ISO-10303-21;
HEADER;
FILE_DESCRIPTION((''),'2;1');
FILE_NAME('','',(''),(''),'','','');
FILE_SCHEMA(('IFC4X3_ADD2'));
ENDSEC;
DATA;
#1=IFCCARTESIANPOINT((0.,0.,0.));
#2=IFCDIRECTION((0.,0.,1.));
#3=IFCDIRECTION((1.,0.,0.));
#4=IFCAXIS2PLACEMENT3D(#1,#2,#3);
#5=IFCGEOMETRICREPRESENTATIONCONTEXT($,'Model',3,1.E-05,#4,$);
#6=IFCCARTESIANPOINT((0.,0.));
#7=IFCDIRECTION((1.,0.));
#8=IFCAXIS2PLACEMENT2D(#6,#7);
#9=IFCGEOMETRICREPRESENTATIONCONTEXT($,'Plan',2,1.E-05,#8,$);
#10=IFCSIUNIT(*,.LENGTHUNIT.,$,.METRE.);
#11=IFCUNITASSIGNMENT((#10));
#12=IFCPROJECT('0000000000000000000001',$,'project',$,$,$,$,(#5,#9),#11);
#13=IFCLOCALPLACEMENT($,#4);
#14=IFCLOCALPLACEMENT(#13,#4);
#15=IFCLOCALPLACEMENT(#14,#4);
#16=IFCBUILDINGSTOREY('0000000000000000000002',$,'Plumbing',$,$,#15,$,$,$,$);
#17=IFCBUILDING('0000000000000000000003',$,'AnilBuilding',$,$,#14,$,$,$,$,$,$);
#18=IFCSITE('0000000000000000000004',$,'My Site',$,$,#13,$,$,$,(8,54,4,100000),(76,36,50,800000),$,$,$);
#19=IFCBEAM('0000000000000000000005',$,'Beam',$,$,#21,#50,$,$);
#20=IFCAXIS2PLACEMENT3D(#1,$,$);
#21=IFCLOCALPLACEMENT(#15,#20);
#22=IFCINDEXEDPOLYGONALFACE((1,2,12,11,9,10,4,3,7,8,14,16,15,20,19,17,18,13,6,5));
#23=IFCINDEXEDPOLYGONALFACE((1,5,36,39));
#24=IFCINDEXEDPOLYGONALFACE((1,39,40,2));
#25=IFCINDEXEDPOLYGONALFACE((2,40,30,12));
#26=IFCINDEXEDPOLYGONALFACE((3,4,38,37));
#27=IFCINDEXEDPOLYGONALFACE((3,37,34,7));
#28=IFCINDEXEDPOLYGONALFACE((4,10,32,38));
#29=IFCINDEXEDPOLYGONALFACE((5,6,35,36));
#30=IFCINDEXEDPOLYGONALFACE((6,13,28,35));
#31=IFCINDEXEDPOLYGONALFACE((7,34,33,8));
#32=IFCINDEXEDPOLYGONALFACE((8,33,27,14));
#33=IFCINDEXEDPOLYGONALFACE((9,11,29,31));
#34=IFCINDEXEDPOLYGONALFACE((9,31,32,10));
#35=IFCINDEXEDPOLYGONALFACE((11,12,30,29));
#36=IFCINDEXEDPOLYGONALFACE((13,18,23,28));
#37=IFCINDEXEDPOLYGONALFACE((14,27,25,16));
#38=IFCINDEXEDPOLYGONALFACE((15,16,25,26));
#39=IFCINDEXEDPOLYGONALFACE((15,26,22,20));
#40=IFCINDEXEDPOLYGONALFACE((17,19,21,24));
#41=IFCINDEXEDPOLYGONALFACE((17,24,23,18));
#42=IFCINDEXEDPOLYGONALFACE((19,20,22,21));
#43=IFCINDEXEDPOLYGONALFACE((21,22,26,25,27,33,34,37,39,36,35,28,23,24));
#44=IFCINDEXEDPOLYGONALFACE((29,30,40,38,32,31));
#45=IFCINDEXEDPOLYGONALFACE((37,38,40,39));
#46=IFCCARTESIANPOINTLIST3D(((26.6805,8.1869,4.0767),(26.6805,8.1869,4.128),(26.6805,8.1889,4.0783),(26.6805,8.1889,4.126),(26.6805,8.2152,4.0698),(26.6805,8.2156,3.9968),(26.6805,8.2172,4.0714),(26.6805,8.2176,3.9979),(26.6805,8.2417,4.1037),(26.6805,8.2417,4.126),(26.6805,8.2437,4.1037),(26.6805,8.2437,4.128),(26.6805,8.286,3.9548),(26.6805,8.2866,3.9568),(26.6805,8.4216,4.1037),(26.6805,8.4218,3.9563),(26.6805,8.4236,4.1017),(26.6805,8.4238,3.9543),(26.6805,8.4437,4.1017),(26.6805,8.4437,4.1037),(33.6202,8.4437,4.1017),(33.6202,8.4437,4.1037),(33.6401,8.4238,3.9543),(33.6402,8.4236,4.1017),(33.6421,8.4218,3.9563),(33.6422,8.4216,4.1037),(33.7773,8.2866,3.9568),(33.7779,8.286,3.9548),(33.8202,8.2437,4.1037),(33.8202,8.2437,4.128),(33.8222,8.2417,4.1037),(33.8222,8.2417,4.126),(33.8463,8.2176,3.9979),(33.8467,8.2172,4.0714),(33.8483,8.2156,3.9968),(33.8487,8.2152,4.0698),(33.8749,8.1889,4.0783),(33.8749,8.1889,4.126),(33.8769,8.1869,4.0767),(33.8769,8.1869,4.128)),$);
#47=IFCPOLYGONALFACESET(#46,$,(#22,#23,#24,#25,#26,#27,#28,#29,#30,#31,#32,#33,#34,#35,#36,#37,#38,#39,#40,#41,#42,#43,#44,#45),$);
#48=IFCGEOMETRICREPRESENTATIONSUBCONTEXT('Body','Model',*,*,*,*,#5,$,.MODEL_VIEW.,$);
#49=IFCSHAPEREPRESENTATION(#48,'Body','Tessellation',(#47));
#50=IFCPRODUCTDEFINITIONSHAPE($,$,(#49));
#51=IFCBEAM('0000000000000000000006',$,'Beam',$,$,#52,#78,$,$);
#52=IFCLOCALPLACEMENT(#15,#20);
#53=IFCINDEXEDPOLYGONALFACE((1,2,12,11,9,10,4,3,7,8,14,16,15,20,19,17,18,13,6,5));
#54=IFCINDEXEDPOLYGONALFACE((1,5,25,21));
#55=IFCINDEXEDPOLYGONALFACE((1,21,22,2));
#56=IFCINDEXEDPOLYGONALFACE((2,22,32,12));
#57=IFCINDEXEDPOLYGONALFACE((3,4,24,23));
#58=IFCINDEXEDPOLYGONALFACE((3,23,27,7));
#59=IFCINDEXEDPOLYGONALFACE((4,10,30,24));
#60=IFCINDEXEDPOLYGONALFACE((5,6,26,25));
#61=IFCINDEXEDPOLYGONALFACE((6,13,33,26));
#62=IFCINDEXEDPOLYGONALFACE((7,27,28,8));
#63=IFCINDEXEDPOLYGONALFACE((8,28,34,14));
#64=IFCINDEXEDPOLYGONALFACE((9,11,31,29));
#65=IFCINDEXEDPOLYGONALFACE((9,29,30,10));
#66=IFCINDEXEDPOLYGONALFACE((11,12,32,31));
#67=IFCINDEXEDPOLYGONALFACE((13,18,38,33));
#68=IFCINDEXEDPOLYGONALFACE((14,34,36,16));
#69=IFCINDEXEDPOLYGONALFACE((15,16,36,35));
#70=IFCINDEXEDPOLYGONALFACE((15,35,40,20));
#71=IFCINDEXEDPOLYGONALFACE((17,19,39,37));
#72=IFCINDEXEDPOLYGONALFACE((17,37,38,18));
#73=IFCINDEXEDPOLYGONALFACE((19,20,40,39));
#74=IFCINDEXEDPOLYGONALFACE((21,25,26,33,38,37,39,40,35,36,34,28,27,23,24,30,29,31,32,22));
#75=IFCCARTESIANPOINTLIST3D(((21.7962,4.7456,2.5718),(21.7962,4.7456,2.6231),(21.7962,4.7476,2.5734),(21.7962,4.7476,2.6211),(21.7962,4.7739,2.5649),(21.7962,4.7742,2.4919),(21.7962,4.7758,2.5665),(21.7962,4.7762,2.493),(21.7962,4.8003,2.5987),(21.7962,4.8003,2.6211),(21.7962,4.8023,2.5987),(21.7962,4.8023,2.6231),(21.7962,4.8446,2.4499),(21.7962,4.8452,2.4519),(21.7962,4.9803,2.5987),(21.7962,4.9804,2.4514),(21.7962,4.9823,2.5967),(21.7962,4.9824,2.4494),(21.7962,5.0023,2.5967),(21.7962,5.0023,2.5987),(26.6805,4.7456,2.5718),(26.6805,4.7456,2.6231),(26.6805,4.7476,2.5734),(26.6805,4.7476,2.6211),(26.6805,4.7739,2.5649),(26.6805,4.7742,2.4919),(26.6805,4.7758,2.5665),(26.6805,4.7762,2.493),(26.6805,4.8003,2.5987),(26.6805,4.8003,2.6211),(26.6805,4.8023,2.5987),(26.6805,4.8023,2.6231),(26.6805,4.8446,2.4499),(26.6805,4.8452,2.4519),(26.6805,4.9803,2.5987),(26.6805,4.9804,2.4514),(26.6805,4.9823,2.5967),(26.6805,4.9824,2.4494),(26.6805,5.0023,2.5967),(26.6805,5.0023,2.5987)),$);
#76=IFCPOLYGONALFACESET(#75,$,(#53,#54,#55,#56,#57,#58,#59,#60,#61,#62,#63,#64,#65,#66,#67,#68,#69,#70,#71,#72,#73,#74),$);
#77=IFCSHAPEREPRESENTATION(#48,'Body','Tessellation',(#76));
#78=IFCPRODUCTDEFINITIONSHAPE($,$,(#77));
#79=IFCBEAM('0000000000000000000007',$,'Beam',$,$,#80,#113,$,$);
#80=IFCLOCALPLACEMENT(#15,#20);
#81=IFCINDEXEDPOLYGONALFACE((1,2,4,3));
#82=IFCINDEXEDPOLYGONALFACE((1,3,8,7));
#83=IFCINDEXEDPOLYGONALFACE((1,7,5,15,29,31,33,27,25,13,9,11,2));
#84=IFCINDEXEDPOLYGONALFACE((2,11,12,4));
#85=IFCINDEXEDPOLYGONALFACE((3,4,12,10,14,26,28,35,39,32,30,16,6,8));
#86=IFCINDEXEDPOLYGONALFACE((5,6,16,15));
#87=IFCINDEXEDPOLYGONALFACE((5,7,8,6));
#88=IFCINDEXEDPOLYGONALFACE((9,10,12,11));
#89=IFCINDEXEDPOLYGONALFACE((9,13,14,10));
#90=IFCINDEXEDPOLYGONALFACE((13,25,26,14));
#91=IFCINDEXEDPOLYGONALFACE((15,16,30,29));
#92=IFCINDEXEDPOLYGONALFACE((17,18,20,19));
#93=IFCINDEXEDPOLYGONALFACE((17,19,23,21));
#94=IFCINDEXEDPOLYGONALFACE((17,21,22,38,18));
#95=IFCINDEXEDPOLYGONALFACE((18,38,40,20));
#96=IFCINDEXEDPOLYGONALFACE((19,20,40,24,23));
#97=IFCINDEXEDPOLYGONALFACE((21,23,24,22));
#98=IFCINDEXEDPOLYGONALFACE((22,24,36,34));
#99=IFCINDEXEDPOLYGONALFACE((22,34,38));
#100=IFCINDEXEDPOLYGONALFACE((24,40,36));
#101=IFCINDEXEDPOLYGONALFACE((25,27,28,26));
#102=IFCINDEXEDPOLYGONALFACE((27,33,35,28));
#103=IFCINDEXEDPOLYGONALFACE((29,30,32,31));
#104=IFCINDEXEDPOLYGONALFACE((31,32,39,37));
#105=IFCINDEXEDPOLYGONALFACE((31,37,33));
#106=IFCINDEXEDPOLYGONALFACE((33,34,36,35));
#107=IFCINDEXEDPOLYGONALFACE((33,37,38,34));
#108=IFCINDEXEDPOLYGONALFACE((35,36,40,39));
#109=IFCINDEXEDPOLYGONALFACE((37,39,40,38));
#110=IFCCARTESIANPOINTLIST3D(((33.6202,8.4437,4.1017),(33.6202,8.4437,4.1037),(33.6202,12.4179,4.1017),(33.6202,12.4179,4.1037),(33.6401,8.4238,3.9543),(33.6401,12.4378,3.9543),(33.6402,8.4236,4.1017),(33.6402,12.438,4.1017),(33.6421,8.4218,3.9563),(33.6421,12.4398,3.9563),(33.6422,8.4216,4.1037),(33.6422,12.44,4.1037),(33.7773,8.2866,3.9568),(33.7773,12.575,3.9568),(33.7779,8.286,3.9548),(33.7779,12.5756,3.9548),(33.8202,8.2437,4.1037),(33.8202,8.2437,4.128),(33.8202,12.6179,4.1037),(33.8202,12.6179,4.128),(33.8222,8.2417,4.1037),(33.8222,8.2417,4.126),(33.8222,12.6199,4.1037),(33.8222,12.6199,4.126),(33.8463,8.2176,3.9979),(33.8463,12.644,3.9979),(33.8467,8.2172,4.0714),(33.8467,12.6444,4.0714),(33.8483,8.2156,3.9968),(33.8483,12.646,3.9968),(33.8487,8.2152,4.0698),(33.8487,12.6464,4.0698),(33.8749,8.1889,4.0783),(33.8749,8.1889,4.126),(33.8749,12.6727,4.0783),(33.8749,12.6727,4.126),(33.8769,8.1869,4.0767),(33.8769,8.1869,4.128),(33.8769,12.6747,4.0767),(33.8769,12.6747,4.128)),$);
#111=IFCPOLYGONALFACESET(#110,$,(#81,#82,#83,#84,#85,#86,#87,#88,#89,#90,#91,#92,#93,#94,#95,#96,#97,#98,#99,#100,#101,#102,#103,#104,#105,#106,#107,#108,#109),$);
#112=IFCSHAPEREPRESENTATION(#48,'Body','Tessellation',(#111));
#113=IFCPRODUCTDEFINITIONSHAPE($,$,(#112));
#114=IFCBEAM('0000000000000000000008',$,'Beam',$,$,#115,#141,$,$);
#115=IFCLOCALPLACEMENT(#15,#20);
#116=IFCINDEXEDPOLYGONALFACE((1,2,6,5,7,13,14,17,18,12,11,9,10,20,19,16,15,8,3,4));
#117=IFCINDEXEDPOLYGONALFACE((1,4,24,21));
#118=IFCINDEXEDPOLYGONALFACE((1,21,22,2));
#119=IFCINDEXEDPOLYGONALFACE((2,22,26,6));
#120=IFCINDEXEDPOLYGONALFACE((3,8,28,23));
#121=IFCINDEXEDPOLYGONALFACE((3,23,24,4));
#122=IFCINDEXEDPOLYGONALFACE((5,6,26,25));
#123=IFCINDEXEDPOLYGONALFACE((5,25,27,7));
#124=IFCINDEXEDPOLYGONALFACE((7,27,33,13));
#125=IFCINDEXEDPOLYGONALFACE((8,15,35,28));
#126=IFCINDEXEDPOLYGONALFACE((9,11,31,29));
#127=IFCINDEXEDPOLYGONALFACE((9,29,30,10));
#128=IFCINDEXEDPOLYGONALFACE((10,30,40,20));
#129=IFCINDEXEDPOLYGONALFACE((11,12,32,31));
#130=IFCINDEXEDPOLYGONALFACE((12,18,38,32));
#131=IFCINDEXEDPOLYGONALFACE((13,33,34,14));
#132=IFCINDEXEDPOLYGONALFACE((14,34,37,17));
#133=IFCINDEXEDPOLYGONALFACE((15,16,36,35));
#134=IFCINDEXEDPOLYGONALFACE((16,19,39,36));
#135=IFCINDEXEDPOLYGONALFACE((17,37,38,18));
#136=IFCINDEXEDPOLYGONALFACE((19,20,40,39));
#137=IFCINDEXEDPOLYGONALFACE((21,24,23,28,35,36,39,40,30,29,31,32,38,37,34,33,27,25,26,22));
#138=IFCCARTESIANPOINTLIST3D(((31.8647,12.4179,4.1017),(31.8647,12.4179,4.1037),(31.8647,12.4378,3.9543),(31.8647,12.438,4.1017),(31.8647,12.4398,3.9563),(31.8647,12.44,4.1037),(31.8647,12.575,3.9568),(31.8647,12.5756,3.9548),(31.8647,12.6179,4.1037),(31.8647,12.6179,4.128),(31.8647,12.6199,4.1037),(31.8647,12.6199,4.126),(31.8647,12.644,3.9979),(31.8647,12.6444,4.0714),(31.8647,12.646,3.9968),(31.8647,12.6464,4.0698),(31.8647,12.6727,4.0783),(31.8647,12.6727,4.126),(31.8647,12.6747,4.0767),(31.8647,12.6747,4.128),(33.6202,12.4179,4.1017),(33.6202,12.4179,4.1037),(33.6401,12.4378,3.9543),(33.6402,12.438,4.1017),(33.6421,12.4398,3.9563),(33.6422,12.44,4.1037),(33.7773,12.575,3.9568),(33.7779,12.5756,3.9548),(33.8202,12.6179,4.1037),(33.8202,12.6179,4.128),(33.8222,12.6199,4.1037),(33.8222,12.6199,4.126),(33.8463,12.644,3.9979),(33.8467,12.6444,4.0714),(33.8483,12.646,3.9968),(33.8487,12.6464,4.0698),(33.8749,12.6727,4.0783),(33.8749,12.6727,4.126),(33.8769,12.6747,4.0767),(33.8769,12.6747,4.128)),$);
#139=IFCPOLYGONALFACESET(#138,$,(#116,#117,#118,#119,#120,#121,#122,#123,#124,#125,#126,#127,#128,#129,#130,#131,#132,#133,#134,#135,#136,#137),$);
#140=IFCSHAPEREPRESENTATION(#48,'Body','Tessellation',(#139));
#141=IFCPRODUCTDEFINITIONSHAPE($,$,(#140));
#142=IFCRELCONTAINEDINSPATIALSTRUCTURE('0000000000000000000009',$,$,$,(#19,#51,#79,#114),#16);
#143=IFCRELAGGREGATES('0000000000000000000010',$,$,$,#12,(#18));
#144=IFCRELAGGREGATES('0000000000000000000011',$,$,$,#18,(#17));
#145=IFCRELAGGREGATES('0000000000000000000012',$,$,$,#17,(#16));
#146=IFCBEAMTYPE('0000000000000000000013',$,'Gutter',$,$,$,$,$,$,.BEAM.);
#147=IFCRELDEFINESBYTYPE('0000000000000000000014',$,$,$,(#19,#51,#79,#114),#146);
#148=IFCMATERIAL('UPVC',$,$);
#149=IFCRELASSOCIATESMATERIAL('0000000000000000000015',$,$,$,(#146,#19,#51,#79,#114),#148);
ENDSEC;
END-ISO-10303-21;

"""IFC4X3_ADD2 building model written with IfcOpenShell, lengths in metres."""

from ifc_helpers import new_model, si_unit, frame, origin_with_axes, origin_2d_with_axis, place, context, subcontext, project, spatial, indexed_curve, outline, extrude, clip, halfspace, material, material_profile, profile_set, profile_usage, type_object, element, save


model = new_model("IFC4X3_ADD2")

# Units and contexts
model_context = context("Model", 3, precision=1e-05, world=origin_with_axes())
plan_context = context("Plan", 2, precision=1e-05, world=origin_2d_with_axis())
body_context = subcontext(model_context, "Body", "Model", "MODEL_VIEW")
ifc_project = project(units=[si_unit("LENGTHUNIT", "METRE")], contexts=[model_context, plan_context])

# Site, building, storey
site_placement = place(None, origin_with_axes())
site = spatial("IfcSite", under=ifc_project, at=site_placement, Name="My Site", RefLatitude=(8, 54, 4, 100000), RefLongitude=(76, 36, 50, 800000))
building_placement = place(site_placement, origin_with_axes())
building = spatial("IfcBuilding", under=site, at=building_placement, Name="AnilBuilding")
storey_placement = place(building_placement, origin_with_axes())
storey = spatial("IfcBuildingStorey", under=building, at=storey_placement, Name="Plumbing")

# Beams
ifc_material_1 = material(Name="UPVC")
ifc_material_profile_1 = material_profile(ifc_material_1, outline(indexed_curve([(0.0548, 0.1717), (0.002, 0.1717), (0.002, 0.124), (0.0303, 0.1171), (0.0307, 0.0436), (0.0996, 0.0025), (0.2349, 0.002), (0.2347, 0.1494), (0.2567, 0.1494), (0.2567, 0.1474), (0.2367, 0.1474), (0.2369, 0.0), (0.0991, 0.0005), (0.0287, 0.0425), (0.0283, 0.1155), (0.0, 0.1224), (0.0, 0.1737), (0.0568, 0.1737), (0.0568, 0.1494), (0.0548, 0.1494), (0.0548, 0.1717)])))
ifc_profile_set_1 = profile_set([ifc_material_profile_1])
ifc_profile_usage_1 = profile_usage(ifc_profile_set_1)
beam_type = type_object("IfcBeamType", Name="Gutter", PredefinedType="BEAM", material=ifc_profile_set_1)
beam_1_placement = place(storey_placement, frame((26.6805, 8.1869, 3.9543), z_axis=(1.0, 0.0, 0.0), x_axis=(0.0, 1.0, 0.0)))
element("IfcBeam", 1, at=beam_1_placement, inside=storey, type_object=beam_type, material=ifc_profile_usage_1, Name="Beam", context=body_context, shape_type="Clipping", body=[
    clip(extrude(outline(indexed_curve([(0.0548, 0.1717), (0.002, 0.1717), (0.002, 0.124), (0.0303, 0.1171), (0.0307, 0.0436), (0.0996, 0.0025), (0.2349, 0.002), (0.2347, 0.1494), (0.2567, 0.1494), (0.2567, 0.1474), (0.2367, 0.1474), (0.2369, 0.0), (0.0991, 0.0005), (0.0287, 0.0425), (0.0283, 0.1155), (0.0, 0.1224), (0.0, 0.1737), (0.0568, 0.1737), (0.0568, 0.1494), (0.0548, 0.1494), (0.0548, 0.1717)])), origin_with_axes(), (0.0, 0.0, 1.0), 7.1965), halfspace(frame((0.0, -3.9543, 7.1965), z_axis=(0.70711, 0.0, 0.707104), x_axis=(0.0, -1.0, 0.0)), False)),
])
ifc_profile_usage_2 = profile_usage(ifc_profile_set_1)
beam_2_placement = place(storey_placement, frame((21.7962, 4.7456, 2.4494), z_axis=(1.0, 0.0, 0.0), x_axis=(0.0, 1.0, 0.0)))
element("IfcBeam", 2, at=beam_2_placement, inside=storey, type_object=beam_type, material=ifc_profile_usage_2, Name="Beam", context=body_context, shape_type="SweptSolid", body=[
    extrude(outline(indexed_curve([(0.0548, 0.1717), (0.002, 0.1717), (0.002, 0.124), (0.0303, 0.1171), (0.0307, 0.0436), (0.0996, 0.0025), (0.2349, 0.002), (0.2347, 0.1494), (0.2567, 0.1494), (0.2567, 0.1474), (0.2367, 0.1474), (0.2369, 0.0), (0.0991, 0.0005), (0.0287, 0.0425), (0.0283, 0.1155), (0.0, 0.1224), (0.0, 0.1737), (0.0568, 0.1737), (0.0568, 0.1494), (0.0548, 0.1494), (0.0548, 0.1717)])), origin_with_axes(), (0.0, 0.0, 1.0), 4.8842),
])
ifc_profile_usage_3 = profile_usage(ifc_profile_set_1)
beam_3_placement = place(storey_placement, frame((33.8769, 8.1869, 3.9543), z_axis=(0.0, 1.0, 0.0), x_axis=(-1.0, 0.0, 0.0)))
element("IfcBeam", 3, at=beam_3_placement, inside=storey, type_object=beam_type, material=ifc_profile_usage_3, Name="Beam", context=body_context, shape_type="Clipping", body=[
    clip(clip(extrude(outline(indexed_curve([(0.0548, 0.1717), (0.002, 0.1717), (0.002, 0.124), (0.0303, 0.1171), (0.0307, 0.0436), (0.0996, 0.0025), (0.2349, 0.002), (0.2347, 0.1494), (0.2567, 0.1494), (0.2567, 0.1474), (0.2367, 0.1474), (0.2369, 0.0), (0.0991, 0.0005), (0.0287, 0.0425), (0.0283, 0.1155), (0.0, 0.1224), (0.0, 0.1737), (0.0568, 0.1737), (0.0568, 0.1494), (0.0548, 0.1494), (0.0548, 0.1717)])), origin_with_axes(), (0.0, 0.0, 1.0), 4.4877), halfspace(frame((0.0, -3.9543, 4.4877), z_axis=(0.707104, 0.0, 0.707109), x_axis=(0.0, -1.0, 0.0)), False)), halfspace(frame((0.0, -3.9543, 0.0), z_axis=(0.707104, 0.0, -0.70711), x_axis=(0.0, -1.0, 0.0)), False)),
])
ifc_profile_usage_4 = profile_usage(ifc_profile_set_1)
beam_4_placement = place(storey_placement, frame((33.8769, 12.6747, 3.9543), z_axis=(-1.0, 0.000001, 0.0), x_axis=(-0.000001, -1.0, 0.0)))
element("IfcBeam", 4, at=beam_4_placement, inside=storey, type_object=beam_type, material=ifc_profile_usage_4, Name="Beam", context=body_context, shape_type="Clipping", body=[
    clip(extrude(outline(indexed_curve([(0.0548, 0.1717), (0.002, 0.1717), (0.002, 0.124), (0.0303, 0.1171), (0.0307, 0.0436), (0.0996, 0.0025), (0.2349, 0.002), (0.2347, 0.1494), (0.2567, 0.1494), (0.2567, 0.1474), (0.2367, 0.1474), (0.2369, 0.0), (0.0991, 0.0005), (0.0287, 0.0425), (0.0283, 0.1155), (0.0, 0.1224), (0.0, 0.1737), (0.0568, 0.1737), (0.0568, 0.1494), (0.0548, 0.1494), (0.0548, 0.1717)])), origin_with_axes(), (0.0, 0.0, 1.0), 2.0122), halfspace(frame((0.0, -3.9543, 0.0), z_axis=(0.707109, 0.0, -0.707105), x_axis=(0.0, -1.0, 0.0)), False)),
])

save(model, "model.ifc")
